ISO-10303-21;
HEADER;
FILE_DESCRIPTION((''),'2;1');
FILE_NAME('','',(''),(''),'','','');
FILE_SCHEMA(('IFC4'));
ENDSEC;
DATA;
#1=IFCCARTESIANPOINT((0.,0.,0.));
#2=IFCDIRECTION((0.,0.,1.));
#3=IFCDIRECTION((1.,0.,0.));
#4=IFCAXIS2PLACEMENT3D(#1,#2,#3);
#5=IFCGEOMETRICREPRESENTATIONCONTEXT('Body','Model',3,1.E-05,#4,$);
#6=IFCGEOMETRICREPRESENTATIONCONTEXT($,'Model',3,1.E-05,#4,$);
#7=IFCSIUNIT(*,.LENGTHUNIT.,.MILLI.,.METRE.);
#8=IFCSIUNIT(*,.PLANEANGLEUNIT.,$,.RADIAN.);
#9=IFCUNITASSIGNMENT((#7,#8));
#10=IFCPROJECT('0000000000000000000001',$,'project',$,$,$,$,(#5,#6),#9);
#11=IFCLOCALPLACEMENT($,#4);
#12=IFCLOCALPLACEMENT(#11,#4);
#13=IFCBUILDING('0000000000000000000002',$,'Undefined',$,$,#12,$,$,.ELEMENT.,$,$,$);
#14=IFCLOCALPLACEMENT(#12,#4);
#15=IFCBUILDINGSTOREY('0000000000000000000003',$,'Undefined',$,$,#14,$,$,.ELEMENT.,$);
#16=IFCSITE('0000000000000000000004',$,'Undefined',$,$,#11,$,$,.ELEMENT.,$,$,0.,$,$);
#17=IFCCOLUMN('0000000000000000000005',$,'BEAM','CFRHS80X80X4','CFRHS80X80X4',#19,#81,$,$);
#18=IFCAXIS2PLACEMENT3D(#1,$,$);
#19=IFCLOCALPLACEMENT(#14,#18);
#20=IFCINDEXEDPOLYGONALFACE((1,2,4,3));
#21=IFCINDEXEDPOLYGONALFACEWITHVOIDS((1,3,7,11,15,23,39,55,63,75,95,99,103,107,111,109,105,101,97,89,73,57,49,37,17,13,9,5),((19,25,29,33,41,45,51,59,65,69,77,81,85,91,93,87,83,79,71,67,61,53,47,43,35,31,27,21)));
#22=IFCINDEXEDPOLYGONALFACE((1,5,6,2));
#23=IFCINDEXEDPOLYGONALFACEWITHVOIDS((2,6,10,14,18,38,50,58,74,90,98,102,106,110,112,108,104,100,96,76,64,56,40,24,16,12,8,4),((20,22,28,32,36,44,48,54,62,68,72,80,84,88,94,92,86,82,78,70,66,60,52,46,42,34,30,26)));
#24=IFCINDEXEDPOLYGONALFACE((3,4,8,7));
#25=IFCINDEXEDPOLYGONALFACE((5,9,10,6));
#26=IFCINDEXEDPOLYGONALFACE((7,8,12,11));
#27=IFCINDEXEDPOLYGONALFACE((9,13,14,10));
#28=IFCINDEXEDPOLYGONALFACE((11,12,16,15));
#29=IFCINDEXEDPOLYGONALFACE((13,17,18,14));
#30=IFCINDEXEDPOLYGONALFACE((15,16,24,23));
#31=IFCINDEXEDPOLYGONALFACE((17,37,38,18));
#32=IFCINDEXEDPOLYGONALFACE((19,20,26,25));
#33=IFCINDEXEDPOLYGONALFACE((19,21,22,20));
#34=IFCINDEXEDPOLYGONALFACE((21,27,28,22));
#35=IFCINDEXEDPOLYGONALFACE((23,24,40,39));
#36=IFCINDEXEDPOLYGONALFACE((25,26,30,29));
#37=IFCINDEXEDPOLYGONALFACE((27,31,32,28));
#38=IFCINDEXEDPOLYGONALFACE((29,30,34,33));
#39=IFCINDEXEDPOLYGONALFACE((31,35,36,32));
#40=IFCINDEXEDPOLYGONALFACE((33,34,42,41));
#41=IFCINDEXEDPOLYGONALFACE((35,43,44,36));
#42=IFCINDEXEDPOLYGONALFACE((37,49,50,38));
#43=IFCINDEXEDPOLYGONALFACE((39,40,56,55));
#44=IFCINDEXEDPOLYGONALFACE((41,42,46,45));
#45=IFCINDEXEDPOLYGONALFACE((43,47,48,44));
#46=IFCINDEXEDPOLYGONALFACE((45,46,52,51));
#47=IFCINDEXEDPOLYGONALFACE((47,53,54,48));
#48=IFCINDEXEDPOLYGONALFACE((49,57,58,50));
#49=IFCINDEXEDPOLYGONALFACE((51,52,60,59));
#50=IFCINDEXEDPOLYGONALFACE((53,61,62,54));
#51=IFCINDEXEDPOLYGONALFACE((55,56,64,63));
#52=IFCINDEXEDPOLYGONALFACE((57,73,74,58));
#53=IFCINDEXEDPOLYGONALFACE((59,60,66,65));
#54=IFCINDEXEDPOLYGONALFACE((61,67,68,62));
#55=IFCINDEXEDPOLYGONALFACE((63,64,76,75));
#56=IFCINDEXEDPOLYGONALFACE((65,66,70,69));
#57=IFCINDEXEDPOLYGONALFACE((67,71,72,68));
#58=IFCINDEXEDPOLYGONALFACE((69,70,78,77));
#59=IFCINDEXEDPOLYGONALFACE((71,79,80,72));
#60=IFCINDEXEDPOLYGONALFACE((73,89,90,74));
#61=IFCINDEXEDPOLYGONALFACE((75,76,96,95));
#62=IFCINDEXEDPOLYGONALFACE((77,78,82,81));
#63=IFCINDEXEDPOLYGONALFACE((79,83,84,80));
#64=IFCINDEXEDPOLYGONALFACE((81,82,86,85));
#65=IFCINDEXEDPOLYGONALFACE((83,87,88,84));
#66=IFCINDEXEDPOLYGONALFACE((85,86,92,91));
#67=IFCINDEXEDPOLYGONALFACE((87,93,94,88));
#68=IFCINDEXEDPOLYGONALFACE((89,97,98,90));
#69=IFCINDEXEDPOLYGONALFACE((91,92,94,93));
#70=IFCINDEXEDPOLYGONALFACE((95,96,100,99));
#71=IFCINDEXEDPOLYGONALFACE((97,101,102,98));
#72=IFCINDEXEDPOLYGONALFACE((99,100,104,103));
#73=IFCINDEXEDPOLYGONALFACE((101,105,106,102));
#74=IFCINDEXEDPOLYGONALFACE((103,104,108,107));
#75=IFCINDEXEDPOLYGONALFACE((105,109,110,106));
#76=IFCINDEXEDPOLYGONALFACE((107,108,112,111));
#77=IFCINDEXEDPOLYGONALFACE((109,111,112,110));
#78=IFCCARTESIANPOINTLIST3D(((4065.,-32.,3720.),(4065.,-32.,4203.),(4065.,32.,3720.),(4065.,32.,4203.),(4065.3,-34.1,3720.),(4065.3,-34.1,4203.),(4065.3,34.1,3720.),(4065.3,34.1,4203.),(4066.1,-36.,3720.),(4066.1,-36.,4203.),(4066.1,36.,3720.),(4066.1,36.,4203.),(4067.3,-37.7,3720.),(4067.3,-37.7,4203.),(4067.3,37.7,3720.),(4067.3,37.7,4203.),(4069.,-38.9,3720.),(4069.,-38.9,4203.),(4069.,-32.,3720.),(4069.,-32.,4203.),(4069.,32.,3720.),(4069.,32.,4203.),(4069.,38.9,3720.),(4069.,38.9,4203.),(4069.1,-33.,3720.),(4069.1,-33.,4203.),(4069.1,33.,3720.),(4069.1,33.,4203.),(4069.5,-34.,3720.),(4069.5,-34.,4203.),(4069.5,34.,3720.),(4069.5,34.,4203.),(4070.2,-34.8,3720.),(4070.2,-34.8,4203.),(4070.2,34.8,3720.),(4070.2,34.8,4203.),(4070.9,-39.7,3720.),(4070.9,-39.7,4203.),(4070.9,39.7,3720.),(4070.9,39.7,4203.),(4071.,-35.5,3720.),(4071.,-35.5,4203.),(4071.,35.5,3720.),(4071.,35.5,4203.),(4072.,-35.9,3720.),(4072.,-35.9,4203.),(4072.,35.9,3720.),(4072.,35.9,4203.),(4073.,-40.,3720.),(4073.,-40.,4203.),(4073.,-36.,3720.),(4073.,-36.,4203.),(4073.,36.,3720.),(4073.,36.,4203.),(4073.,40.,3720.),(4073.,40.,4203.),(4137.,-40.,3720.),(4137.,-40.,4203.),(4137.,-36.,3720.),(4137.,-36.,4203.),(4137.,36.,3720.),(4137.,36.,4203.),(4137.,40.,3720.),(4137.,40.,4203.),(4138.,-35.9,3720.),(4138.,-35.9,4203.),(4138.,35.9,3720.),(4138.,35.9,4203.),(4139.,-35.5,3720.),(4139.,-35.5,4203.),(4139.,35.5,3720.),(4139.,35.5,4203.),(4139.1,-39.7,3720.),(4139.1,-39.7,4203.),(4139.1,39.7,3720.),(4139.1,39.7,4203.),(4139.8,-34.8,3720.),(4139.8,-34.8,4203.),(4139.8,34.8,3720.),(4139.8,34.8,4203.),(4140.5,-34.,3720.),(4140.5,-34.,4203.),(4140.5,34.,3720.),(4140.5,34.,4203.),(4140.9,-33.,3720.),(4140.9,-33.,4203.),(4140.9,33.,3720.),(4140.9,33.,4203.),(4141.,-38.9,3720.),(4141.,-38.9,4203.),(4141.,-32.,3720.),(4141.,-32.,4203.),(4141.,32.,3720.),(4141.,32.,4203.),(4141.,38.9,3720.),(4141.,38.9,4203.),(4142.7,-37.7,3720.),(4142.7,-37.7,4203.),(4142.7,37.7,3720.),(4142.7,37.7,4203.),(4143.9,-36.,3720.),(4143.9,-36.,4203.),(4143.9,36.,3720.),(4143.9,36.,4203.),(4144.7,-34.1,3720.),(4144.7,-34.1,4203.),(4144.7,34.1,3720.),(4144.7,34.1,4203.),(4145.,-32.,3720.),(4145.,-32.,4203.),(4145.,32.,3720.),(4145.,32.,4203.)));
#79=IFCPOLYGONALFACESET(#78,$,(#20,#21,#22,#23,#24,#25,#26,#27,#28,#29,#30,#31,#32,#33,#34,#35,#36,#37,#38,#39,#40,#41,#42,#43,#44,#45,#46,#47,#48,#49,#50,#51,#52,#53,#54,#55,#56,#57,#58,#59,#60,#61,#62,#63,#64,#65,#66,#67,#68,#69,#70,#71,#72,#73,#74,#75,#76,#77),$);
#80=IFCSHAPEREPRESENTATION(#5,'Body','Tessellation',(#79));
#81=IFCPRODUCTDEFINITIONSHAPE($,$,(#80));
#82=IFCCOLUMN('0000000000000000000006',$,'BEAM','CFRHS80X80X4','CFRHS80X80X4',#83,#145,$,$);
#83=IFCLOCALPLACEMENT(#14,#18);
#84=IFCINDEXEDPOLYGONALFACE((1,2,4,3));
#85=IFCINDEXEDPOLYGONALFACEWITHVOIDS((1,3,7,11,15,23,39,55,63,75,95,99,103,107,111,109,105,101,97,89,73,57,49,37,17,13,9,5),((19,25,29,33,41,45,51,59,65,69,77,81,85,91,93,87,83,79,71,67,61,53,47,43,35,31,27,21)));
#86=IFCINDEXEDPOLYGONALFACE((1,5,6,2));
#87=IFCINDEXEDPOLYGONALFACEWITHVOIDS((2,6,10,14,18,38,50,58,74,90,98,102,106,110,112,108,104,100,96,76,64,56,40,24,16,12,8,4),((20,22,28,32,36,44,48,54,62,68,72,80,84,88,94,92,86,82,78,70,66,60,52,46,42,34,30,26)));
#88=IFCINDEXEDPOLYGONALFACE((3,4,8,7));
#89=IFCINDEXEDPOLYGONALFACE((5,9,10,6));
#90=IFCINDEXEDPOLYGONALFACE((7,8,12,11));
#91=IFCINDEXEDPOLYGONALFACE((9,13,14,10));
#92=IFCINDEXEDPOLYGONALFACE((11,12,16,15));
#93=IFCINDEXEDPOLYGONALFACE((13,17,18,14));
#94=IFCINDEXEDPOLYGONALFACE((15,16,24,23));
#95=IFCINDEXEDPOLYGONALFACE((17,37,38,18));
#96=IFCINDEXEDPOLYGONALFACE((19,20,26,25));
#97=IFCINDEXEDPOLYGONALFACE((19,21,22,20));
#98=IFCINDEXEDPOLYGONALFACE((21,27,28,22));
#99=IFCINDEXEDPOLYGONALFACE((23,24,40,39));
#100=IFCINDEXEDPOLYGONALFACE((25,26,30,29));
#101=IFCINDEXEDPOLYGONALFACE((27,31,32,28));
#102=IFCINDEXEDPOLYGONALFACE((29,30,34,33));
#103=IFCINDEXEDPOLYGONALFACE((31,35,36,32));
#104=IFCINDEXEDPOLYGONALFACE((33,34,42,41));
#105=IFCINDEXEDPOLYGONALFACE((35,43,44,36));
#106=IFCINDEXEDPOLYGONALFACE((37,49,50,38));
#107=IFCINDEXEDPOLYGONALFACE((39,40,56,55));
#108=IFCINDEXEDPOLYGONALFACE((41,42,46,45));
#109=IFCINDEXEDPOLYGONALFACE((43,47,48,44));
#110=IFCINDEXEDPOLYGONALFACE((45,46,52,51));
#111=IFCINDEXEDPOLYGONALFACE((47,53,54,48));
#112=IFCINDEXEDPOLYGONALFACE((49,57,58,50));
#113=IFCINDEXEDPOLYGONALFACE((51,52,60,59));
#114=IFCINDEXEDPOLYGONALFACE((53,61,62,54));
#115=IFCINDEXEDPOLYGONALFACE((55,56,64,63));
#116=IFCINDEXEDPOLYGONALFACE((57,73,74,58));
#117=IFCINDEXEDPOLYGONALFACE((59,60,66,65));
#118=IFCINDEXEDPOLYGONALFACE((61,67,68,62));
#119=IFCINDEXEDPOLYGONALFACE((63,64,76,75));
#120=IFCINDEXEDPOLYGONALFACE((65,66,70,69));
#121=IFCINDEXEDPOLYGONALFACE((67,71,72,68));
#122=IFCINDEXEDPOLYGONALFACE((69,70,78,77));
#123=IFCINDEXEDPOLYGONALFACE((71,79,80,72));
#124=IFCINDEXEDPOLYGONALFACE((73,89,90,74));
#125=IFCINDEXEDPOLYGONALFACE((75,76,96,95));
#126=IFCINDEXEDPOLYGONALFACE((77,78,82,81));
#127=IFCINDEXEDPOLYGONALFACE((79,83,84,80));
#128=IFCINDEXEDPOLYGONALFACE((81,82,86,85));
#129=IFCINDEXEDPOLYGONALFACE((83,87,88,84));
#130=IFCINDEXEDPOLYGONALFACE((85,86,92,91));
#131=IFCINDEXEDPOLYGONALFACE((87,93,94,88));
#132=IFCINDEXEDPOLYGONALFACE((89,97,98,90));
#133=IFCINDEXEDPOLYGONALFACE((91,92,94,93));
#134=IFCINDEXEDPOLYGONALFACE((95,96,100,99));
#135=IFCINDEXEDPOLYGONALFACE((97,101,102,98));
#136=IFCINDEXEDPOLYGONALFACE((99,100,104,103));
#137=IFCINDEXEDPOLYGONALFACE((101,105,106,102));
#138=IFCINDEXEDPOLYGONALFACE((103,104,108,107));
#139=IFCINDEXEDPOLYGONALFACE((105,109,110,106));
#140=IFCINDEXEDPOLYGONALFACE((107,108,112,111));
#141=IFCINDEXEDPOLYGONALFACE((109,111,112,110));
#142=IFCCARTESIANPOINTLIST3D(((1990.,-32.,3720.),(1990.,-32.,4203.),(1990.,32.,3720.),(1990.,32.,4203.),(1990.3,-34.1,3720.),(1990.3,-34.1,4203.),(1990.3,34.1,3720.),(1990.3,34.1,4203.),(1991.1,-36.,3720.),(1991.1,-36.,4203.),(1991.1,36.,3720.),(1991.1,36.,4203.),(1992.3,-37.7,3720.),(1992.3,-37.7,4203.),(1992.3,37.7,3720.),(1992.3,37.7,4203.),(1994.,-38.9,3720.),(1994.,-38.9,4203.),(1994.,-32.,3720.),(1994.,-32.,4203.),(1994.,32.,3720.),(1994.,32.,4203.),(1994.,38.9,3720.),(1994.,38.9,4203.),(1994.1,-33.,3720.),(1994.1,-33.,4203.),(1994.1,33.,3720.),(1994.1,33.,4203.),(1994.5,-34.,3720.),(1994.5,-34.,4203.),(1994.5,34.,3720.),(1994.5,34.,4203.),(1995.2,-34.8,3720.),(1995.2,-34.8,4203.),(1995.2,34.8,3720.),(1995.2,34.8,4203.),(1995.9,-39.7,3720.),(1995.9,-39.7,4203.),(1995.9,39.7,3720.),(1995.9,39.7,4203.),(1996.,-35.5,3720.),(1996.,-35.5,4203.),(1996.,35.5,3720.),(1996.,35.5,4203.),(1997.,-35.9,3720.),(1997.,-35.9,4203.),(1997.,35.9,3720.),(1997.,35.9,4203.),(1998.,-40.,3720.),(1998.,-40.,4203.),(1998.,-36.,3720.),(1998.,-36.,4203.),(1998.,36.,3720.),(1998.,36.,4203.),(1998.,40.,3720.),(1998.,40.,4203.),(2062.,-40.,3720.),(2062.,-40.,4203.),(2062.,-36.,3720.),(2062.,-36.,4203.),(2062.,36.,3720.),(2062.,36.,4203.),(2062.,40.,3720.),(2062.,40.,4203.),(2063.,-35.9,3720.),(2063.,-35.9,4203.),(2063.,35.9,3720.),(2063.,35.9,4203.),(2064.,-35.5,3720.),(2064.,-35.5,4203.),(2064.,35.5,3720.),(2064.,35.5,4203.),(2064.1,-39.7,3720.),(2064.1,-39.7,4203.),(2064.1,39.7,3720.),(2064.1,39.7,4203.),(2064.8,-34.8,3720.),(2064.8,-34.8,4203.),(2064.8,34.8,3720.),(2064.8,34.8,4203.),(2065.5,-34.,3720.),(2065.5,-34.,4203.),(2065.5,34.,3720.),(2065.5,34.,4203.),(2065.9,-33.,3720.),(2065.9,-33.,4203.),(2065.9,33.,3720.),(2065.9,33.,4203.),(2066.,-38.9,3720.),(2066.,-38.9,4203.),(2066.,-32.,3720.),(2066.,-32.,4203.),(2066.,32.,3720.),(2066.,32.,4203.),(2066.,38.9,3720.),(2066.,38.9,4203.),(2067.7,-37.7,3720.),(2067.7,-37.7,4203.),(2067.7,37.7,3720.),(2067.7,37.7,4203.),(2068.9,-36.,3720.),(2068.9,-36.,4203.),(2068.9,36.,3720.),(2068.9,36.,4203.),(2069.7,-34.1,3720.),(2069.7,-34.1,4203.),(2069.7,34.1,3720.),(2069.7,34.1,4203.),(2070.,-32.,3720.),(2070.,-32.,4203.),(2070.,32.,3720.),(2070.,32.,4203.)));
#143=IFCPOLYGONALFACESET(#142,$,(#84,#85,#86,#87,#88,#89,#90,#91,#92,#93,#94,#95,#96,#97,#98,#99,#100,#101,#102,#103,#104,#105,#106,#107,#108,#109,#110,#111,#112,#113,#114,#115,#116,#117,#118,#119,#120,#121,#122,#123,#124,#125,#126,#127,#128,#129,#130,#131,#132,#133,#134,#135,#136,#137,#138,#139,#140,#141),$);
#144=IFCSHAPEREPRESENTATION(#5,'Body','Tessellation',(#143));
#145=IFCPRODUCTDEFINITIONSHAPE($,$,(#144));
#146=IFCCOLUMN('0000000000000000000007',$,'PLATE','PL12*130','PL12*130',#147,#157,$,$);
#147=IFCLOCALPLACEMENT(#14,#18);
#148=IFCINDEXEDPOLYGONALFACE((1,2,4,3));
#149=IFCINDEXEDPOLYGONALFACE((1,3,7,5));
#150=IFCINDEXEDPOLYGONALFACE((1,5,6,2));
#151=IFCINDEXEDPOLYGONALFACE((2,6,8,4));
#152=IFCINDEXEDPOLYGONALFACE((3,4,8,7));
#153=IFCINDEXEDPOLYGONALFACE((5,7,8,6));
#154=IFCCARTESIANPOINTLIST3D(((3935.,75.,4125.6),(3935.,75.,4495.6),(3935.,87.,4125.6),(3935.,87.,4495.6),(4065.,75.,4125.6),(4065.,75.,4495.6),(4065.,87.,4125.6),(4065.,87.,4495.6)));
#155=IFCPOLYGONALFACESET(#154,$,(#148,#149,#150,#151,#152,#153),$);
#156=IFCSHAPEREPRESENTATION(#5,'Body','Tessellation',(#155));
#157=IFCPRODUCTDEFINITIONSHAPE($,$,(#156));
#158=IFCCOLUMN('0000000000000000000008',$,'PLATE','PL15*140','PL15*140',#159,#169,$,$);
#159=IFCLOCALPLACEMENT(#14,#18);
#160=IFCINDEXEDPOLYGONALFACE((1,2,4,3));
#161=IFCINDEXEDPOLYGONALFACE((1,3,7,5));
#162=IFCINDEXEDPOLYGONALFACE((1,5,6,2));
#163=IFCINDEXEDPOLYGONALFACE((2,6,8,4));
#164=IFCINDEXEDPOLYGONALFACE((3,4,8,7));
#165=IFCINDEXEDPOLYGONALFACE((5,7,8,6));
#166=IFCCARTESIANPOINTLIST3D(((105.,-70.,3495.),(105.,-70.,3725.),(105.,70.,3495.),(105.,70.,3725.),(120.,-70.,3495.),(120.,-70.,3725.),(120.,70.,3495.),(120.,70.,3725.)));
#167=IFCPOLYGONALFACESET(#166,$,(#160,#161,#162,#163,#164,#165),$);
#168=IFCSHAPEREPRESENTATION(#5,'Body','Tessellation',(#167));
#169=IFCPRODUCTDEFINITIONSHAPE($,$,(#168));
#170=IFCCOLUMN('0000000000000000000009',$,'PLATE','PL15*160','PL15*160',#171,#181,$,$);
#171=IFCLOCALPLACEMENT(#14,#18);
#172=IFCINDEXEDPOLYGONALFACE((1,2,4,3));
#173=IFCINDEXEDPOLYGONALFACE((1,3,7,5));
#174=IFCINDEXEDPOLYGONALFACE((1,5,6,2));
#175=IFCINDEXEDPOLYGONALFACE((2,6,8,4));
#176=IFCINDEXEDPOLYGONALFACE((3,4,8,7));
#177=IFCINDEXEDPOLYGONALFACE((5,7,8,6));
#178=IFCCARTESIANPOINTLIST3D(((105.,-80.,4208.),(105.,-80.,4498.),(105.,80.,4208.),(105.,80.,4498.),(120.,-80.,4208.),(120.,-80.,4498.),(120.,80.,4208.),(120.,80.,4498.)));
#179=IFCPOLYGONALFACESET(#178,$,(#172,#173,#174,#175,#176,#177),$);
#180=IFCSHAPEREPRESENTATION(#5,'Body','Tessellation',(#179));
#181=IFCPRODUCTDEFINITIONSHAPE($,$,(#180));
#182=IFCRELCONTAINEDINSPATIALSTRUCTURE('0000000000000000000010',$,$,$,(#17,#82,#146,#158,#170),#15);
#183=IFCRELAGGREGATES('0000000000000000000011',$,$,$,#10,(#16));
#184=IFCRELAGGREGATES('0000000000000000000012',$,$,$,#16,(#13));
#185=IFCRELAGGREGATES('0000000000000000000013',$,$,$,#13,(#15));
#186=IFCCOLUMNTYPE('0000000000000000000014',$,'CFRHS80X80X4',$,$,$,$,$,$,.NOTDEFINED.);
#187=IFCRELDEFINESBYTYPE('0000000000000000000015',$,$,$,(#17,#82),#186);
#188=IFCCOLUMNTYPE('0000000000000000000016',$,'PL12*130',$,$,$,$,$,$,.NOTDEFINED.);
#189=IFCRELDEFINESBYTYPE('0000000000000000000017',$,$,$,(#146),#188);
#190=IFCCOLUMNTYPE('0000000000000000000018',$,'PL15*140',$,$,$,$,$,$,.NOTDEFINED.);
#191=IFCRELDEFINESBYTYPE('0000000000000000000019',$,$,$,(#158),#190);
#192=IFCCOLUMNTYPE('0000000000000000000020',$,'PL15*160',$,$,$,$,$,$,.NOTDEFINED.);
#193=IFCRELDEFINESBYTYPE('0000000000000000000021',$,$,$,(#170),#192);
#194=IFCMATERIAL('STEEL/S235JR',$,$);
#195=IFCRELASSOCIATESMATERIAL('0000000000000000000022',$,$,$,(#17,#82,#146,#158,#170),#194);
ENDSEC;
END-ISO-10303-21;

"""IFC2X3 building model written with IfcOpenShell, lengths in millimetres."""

from ifc_helpers import new_model, si_unit, frame, origin_with_axes, origin_2d_with_axis, place, context, project, spatial, rectangle, hollow_rectangle, extrude, material, type_object, element, save


model = new_model("IFC2X3")

# Units and contexts
model_context_1 = context("Model", 3, precision=1e-05, world=origin_with_axes(), identifier="Body")
model_context_2 = context("Model", 3, precision=1e-05, world=origin_with_axes())
ifc_project = project(units=[si_unit("LENGTHUNIT", "METRE", prefix="MILLI"), si_unit("PLANEANGLEUNIT", "RADIAN")], contexts=[model_context_1, model_context_2])

# Site, building, storey
site_placement = place(None, origin_with_axes())
site = spatial("IfcSite", under=ifc_project, at=site_placement, Name="Undefined", CompositionType="ELEMENT", RefElevation=0.0)
building_placement = place(site_placement, origin_with_axes())
building = spatial("IfcBuilding", under=site, at=building_placement, Name="Undefined", CompositionType="ELEMENT")
storey_placement = place(building_placement, origin_with_axes())
storey = spatial("IfcBuildingStorey", under=building, at=storey_placement, Name="Undefined", CompositionType="ELEMENT")

# Columns
ifc_material = material(Name="STEEL/S235JR")
column_type_1 = type_object("IfcColumnType", Name="CFRHS80X80X4", PredefinedType="NOTDEFINED")
for number, where, z_axis, x_axis, name in (
    (1, (4105.0, 0.0, 3720.0), (0.0, 0.0, 1.0), (1.0, 0.0, 0.0), "BEAM"),
):
    element("IfcColumn", number, at=place(storey_placement, frame(where, z_axis=z_axis, x_axis=x_axis)), inside=storey, type_object=column_type_1, material=ifc_material, Name=name, Description="CFRHS80X80X4", ObjectType="CFRHS80X80X4", context=model_context_1, shape_type="SweptSolid", body=[
        extrude(hollow_rectangle(XDim=80.0, YDim=80.0, WallThickness=4.0, InnerFilletRadius=4.0, OuterFilletRadius=8.0, at=origin_2d_with_axis()), frame((0.0, 0.0, 483.0), z_axis=(0.0, 0.0, -1.0), x_axis=(0.0, 1.0, 0.0)), (0.0, 0.0, 1.0), 483.0),
    ])
column_1_placement = place(storey_placement, frame((2030.0, 0.0, 3720.0), z_axis=(0.0, 0.0, 1.0), x_axis=(1.0, 0.0, 0.0)))
element("IfcColumn", 2, at=column_1_placement, inside=storey, type_object=column_type_1, material=ifc_material, Name="BEAM", Description="CFRHS80X80X4", ObjectType="CFRHS80X80X4", context=model_context_1, shape_type="SweptSolid", body=[
    extrude(hollow_rectangle(XDim=80.0, YDim=80.0, WallThickness=4.0, InnerFilletRadius=4.0, OuterFilletRadius=8.0, at=origin_2d_with_axis()), frame((0.0, 0.0, 483.0), z_axis=(0.0, 0.0, -1.0), x_axis=(0.0, -1.0, 0.0)), (0.0, 0.0, 1.0), 483.0),
])
column_type_2 = type_object("IfcColumnType", Name="PL12*130", PredefinedType="NOTDEFINED")
column_2_placement = place(storey_placement, frame((4000.0, 81.0, 4125.6), z_axis=(0.0, 0.0, 1.0), x_axis=(1.0, 0.0, 0.0)))
element("IfcColumn", 3, at=column_2_placement, inside=storey, type_object=column_type_2, material=ifc_material, Name="PLATE", Description="PL12*130", ObjectType="PL12*130", context=model_context_1, shape_type="SweptSolid", body=[
    extrude(rectangle(XDim=12.0, YDim=130.0, at=origin_2d_with_axis()), frame((0.0, 0.0, 370.0), z_axis=(0.0, 0.0, -1.0), x_axis=(0.0, 1.0, 0.0)), (0.0, 0.0, 1.0), 370.0),
])
column_type_3 = type_object("IfcColumnType", Name="PL15*140", PredefinedType="NOTDEFINED")
column_3_placement = place(storey_placement, frame((112.5, 0.0, 3495.0), z_axis=(0.0, 0.0, 1.0), x_axis=(1.0, 0.0, 0.0)))
element("IfcColumn", 4, at=column_3_placement, inside=storey, type_object=column_type_3, material=ifc_material, Name="PLATE", Description="PL15*140", ObjectType="PL15*140", context=model_context_1, shape_type="SweptSolid", body=[
    extrude(rectangle(XDim=15.0, YDim=140.0, at=origin_2d_with_axis()), frame((0.0, 0.0, 230.0), z_axis=(0.0, 0.0, -1.0), x_axis=(1.0, 0.0, 0.0)), (0.0, 0.0, 1.0), 230.0),
])
column_type_4 = type_object("IfcColumnType", Name="PL15*160", PredefinedType="NOTDEFINED")
column_4_placement = place(storey_placement, frame((112.5, 0.0, 4208.0), z_axis=(0.0, 0.0, 1.0), x_axis=(1.0, 0.0, 0.0)))
element("IfcColumn", 5, at=column_4_placement, inside=storey, type_object=column_type_4, material=ifc_material, Name="PLATE", Description="PL15*160", ObjectType="PL15*160", context=model_context_1, shape_type="SweptSolid", body=[
    extrude(rectangle(XDim=15.0, YDim=160.0, at=origin_2d_with_axis()), frame((0.0, 0.0, 290.0), z_axis=(0.0, 0.0, -1.0), x_axis=(1.0, 0.0, 0.0)), (0.0, 0.0, 1.0), 290.0),
])

save(model, "model.ifc")
